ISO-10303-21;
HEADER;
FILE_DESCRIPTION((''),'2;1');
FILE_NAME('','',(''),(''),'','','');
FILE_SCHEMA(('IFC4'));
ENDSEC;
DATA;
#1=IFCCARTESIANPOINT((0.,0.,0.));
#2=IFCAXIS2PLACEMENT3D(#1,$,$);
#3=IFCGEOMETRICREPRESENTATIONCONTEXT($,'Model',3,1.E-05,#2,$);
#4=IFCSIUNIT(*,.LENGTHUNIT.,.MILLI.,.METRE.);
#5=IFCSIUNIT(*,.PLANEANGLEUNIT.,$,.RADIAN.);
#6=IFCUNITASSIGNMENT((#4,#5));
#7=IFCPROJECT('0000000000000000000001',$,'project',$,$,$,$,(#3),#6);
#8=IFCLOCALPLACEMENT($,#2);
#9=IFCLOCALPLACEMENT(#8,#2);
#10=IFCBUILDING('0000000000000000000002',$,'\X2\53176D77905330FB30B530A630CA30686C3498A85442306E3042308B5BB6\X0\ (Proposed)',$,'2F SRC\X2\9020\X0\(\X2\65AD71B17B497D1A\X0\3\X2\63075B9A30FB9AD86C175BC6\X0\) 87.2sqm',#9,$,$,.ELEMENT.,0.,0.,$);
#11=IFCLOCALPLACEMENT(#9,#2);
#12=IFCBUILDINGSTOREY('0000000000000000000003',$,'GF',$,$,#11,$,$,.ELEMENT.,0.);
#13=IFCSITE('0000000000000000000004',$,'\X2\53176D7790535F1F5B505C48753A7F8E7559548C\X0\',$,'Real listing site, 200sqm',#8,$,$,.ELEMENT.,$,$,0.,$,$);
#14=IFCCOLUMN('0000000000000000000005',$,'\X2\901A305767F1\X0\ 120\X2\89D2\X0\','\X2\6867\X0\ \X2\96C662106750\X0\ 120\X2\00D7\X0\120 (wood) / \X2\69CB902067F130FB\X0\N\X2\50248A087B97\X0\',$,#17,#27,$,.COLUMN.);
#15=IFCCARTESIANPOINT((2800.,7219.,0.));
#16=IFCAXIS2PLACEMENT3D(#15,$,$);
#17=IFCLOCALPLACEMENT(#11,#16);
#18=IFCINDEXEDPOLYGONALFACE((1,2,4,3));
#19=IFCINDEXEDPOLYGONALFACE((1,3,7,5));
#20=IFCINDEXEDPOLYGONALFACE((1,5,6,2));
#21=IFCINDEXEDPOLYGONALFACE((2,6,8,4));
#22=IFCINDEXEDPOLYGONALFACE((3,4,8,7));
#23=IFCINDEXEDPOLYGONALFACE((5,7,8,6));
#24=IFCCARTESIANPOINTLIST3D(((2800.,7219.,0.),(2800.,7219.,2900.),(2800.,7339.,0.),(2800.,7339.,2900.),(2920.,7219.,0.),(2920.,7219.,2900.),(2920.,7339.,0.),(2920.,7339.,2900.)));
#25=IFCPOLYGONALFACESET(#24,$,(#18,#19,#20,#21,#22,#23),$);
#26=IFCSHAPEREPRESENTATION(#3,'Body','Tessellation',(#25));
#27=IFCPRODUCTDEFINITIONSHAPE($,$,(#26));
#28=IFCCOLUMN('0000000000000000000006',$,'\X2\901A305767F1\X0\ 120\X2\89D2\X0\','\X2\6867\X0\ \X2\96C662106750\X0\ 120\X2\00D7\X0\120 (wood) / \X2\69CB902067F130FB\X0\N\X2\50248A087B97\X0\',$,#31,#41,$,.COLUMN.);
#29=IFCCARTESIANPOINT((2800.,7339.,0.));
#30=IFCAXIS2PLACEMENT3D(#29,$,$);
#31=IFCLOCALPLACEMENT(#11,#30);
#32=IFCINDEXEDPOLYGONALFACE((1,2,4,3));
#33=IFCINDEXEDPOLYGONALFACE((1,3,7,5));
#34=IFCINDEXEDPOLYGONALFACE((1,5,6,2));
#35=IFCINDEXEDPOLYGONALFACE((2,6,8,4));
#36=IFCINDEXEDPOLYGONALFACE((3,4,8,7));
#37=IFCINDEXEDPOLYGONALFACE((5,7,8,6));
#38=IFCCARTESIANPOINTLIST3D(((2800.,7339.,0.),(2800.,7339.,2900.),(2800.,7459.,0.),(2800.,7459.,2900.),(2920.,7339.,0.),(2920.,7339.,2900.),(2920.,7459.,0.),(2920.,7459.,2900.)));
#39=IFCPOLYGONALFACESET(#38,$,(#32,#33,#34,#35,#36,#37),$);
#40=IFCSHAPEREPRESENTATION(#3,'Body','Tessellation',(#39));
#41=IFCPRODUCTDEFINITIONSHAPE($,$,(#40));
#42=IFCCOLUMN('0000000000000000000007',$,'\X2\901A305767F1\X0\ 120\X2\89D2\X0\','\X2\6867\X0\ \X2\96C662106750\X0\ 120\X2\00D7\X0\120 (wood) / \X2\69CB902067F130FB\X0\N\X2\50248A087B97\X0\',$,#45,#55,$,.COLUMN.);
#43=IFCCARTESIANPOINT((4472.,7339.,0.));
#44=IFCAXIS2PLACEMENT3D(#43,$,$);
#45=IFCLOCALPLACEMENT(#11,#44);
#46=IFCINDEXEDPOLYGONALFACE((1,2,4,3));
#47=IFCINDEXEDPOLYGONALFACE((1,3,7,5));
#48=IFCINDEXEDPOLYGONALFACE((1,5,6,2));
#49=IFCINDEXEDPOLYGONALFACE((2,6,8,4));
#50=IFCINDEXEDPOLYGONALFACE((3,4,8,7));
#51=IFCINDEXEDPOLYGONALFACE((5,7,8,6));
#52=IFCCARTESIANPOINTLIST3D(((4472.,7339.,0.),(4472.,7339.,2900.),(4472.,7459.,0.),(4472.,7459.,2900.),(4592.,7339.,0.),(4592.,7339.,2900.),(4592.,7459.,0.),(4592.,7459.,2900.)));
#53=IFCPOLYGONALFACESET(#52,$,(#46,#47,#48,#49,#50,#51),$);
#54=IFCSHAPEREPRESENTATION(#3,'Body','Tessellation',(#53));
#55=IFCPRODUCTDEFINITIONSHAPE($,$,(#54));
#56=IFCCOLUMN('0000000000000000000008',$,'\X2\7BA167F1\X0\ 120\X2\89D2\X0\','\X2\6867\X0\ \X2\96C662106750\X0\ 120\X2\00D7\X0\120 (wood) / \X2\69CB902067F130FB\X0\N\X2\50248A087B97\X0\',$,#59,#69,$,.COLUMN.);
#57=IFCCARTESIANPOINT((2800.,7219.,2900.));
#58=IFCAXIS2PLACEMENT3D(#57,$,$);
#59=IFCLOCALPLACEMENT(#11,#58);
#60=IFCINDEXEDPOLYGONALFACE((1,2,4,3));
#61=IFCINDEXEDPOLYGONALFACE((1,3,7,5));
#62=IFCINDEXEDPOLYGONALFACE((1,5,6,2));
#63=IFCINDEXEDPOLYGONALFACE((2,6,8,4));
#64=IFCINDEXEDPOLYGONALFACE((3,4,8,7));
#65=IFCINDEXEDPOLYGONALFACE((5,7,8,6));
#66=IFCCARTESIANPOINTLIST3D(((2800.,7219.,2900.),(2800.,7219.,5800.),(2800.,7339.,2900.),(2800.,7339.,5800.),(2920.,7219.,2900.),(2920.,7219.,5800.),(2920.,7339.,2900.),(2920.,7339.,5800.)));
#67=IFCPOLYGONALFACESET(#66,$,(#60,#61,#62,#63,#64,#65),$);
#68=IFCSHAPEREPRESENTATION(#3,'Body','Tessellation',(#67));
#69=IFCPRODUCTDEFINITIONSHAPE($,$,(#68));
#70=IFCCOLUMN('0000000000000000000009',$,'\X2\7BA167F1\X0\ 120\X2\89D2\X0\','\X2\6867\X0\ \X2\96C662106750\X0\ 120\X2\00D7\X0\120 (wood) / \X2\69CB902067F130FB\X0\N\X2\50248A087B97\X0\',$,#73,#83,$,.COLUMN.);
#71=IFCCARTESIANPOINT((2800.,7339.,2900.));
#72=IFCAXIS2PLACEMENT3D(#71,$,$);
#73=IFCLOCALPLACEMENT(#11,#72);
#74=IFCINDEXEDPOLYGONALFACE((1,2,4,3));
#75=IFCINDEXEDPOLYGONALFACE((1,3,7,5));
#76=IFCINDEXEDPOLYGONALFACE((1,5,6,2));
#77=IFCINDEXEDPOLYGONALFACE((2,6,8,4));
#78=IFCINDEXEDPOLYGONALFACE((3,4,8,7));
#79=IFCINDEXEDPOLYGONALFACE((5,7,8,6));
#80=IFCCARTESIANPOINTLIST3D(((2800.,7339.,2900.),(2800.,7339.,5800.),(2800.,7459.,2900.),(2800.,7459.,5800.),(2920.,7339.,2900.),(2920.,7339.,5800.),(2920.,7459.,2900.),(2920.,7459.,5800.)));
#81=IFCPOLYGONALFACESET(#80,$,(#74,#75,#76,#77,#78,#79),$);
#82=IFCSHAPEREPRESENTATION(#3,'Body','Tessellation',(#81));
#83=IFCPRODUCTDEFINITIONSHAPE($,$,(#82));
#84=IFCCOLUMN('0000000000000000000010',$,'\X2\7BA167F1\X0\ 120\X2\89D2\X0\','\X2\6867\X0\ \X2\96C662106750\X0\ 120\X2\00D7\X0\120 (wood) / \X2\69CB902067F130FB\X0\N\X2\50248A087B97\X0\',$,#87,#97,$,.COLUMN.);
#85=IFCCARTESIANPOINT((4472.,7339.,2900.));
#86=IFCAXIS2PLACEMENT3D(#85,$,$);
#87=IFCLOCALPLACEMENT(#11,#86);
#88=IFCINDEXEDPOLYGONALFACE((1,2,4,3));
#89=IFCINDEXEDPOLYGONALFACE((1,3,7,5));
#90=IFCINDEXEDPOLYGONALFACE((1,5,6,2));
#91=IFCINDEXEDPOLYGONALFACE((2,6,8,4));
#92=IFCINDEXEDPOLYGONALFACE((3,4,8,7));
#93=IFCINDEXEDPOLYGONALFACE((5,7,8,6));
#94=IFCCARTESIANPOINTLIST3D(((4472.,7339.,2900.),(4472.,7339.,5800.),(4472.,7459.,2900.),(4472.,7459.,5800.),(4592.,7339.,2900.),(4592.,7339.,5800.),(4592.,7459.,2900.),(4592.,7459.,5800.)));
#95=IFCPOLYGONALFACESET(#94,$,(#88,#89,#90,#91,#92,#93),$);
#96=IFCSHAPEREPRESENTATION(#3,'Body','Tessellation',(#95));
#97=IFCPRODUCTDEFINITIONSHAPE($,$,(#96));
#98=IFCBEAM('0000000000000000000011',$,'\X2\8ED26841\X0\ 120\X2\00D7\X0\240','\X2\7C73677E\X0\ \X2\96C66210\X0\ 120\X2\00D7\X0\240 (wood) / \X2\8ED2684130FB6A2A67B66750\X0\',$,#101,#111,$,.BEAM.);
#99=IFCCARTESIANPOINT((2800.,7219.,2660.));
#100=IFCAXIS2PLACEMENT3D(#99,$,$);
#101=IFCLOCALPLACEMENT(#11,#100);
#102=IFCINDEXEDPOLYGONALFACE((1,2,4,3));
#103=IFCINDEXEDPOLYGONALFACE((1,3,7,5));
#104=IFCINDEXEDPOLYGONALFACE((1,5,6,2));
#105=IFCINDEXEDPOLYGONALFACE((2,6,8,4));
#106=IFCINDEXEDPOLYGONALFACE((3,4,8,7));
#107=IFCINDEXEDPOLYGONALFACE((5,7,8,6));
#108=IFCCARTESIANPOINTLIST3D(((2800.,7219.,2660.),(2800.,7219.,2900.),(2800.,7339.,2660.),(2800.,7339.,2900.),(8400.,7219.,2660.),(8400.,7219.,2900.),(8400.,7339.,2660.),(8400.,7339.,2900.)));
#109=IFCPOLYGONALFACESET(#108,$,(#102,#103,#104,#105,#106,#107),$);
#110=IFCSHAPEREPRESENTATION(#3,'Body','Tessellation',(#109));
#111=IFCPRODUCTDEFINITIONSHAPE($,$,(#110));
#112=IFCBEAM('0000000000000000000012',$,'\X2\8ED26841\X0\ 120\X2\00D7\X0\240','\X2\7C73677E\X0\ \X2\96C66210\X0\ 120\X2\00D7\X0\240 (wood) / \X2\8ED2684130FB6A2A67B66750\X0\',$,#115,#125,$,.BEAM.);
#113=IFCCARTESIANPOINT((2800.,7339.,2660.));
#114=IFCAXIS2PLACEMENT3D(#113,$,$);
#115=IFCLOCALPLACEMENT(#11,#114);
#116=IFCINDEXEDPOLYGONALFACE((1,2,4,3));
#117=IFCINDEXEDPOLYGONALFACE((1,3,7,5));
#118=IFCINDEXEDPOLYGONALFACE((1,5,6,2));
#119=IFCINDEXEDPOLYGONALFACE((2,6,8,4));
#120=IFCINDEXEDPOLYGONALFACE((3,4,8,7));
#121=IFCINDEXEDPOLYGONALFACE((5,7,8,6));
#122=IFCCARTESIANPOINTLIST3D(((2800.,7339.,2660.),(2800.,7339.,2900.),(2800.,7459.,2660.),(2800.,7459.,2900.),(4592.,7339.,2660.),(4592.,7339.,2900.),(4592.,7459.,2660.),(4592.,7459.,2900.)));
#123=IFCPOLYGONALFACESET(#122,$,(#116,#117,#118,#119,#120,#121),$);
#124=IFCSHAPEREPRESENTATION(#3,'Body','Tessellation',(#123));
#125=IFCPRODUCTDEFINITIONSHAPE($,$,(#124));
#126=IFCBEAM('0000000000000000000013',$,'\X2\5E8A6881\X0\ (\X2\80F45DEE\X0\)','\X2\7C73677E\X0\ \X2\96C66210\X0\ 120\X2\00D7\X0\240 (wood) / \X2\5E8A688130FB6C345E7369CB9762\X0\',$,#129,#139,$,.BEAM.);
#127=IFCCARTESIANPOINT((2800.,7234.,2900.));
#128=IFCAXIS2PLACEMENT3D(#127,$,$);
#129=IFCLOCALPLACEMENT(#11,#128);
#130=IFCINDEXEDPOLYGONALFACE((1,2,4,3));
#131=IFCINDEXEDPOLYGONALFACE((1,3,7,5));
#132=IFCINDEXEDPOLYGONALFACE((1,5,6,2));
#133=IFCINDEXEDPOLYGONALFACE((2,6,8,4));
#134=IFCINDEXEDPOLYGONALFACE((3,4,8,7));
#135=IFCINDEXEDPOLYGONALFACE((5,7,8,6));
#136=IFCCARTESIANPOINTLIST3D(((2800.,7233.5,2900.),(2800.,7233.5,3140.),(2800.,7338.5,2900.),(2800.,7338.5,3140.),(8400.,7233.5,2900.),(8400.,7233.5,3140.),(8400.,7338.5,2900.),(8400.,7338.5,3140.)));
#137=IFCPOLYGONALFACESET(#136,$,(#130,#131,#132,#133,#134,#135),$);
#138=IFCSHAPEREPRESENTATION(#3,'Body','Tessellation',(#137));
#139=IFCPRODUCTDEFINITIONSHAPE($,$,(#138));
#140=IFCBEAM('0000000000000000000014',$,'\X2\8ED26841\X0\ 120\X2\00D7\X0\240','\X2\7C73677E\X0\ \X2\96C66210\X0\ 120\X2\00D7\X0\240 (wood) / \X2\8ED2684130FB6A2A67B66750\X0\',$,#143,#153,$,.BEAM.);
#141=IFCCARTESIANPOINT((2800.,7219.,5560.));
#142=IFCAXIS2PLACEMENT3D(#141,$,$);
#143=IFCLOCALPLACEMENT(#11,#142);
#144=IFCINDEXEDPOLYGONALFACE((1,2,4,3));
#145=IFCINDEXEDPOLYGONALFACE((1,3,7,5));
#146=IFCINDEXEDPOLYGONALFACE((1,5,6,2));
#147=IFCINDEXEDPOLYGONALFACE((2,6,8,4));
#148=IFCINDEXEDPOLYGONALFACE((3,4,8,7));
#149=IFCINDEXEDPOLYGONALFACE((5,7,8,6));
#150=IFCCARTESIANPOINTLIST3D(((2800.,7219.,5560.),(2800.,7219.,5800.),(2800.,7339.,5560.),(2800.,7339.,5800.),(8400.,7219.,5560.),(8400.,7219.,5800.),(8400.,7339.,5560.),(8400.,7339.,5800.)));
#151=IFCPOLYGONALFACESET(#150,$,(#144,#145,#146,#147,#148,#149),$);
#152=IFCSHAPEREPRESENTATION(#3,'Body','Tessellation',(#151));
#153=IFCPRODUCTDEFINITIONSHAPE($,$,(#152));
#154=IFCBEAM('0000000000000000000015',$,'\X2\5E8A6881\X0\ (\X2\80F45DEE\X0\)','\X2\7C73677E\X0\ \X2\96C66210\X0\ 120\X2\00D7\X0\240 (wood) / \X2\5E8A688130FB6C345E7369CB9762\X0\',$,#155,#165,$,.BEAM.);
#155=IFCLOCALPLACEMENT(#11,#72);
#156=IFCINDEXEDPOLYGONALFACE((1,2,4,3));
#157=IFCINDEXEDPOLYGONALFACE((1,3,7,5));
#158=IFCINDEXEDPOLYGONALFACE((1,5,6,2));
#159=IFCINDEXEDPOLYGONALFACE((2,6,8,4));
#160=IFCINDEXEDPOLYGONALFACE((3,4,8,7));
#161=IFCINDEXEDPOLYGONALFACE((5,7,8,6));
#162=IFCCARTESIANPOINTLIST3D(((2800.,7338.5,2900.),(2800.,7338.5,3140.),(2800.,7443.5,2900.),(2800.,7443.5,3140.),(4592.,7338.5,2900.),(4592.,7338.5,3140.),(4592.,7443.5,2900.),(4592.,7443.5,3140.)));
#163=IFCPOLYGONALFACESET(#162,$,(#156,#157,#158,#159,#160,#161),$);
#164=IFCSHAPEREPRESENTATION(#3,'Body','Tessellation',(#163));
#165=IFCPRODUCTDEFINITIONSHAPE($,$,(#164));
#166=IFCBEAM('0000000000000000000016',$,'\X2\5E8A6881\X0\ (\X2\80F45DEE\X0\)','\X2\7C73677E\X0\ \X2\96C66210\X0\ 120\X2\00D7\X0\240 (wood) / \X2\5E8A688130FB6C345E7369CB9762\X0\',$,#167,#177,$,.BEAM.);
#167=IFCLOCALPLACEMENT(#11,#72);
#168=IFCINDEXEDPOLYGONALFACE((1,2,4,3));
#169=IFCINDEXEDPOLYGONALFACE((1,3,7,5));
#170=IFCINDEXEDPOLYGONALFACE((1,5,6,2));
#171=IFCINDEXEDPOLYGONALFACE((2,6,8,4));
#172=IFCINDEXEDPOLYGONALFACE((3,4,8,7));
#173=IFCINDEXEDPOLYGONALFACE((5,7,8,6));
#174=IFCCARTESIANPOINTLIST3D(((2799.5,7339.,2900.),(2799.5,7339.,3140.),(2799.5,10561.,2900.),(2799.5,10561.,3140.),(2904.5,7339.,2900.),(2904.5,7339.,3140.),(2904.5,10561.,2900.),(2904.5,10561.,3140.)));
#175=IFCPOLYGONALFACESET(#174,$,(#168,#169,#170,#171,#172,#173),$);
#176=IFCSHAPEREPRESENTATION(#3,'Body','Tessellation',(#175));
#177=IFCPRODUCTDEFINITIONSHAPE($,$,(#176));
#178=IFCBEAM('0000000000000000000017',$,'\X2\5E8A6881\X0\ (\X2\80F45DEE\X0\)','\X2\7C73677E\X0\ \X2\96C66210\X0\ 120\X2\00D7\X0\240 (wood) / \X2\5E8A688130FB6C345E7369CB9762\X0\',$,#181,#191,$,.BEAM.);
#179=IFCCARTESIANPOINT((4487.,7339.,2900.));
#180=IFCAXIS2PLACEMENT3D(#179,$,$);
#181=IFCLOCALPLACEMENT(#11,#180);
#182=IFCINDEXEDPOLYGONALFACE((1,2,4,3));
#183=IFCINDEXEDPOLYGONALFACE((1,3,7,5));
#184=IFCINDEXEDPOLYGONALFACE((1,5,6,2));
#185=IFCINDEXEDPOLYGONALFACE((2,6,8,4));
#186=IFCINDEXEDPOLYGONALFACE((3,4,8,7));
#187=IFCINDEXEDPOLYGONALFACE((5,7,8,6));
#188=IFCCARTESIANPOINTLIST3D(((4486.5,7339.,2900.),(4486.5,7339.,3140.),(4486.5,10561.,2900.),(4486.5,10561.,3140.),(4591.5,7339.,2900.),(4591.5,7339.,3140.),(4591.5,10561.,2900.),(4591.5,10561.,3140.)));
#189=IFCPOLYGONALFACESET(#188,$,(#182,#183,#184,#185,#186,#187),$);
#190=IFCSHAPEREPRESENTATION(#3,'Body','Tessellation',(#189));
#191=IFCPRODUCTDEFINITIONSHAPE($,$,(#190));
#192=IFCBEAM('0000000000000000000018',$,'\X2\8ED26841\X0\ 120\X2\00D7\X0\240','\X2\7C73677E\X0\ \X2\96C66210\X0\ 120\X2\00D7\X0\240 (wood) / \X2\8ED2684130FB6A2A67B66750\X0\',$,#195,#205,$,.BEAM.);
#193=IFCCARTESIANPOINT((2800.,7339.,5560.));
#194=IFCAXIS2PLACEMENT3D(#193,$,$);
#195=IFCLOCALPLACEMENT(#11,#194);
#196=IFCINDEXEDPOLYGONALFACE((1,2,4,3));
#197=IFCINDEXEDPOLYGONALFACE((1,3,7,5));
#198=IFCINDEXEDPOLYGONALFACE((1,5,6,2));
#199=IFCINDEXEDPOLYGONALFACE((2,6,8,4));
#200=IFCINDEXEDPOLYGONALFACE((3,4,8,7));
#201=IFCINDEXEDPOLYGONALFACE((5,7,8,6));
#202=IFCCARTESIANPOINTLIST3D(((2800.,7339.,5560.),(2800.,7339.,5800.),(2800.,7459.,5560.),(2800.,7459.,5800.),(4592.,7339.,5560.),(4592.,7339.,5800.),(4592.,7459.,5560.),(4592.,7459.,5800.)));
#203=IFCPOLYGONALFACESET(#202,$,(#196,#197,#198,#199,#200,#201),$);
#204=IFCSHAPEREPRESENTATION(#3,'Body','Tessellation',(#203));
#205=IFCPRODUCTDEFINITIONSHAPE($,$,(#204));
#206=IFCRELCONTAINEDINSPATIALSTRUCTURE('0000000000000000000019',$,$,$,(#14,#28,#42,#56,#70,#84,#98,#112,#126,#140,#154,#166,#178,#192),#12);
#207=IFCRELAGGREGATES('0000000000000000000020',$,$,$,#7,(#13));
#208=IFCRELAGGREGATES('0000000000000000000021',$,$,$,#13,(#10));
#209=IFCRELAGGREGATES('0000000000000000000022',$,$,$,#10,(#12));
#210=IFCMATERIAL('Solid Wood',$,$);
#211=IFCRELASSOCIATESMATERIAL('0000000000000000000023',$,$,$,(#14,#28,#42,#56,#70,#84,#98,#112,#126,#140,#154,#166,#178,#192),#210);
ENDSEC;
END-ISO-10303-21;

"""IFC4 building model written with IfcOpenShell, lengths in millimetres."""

from ifc_helpers import new_model, si_unit, frame, frame_2d, origin, place, context, project, spatial, rectangle, extrude, material, element, save


model = new_model("IFC4")

# Units and contexts
model_context = context("Model", 3, precision=1e-05, world=origin())
ifc_project = project(units=[si_unit("LENGTHUNIT", "METRE", prefix="MILLI"), si_unit("PLANEANGLEUNIT", "RADIAN")], contexts=[model_context])

# Site, building, storey
site_placement = place(None, origin())
site = spatial("IfcSite", under=ifc_project, at=site_placement, Name="北海道弟子屈町美留和", ObjectType="Real listing site, 200sqm", CompositionType="ELEMENT", RefElevation=0.0)
building_placement = place(site_placement, origin())
building = spatial("IfcBuilding", under=site, at=building_placement, Name="北海道・サウナと水風呂のある家 (Proposed)", ObjectType="2F SRC造(断熱等級3指定・高気密) 87.2sqm", CompositionType="ELEMENT", ElevationOfRefHeight=0.0, ElevationOfTerrain=0.0)
storey_placement = place(building_placement, origin())
storey = spatial("IfcBuildingStorey", under=building, at=storey_placement, Name="GF", CompositionType="ELEMENT", Elevation=0.0)

# Columns
ifc_material_1 = material(Name="Solid Wood")
column_1_placement = place(storey_placement, frame((2800.0, 7219.0, 0.0)))
element("IfcColumn", 1, at=column_1_placement, inside=storey, material=ifc_material_1, Name="通し柱 120角", Description="桧 集成材 120×120 (wood) / 構造柱・N値計算", PredefinedType="COLUMN", context=model_context, shape_type="SweptSolid", body=[
    extrude(rectangle(XDim=120.0, YDim=120.0, at=frame_2d((60.0, 60.0))), frame((2800.0, 7219.0, 0.0)), (0.0, 0.0, 1.0), 2900.0),
])
column_2_placement = place(storey_placement, frame((2800.0, 7339.0, 0.0)))
element("IfcColumn", 2, at=column_2_placement, inside=storey, material=ifc_material_1, Name="通し柱 120角", Description="桧 集成材 120×120 (wood) / 構造柱・N値計算", PredefinedType="COLUMN", context=model_context, shape_type="SweptSolid", body=[
    extrude(rectangle(XDim=120.0, YDim=120.0, at=frame_2d((60.0, 60.0))), frame((2800.0, 7339.0, 0.0)), (0.0, 0.0, 1.0), 2900.0),
])
column_3_placement = place(storey_placement, frame((4472.0, 7339.0, 0.0)))
element("IfcColumn", 3, at=column_3_placement, inside=storey, material=ifc_material_1, Name="通し柱 120角", Description="桧 集成材 120×120 (wood) / 構造柱・N値計算", PredefinedType="COLUMN", context=model_context, shape_type="SweptSolid", body=[
    extrude(rectangle(XDim=120.0, YDim=120.0, at=frame_2d((60.0, 60.0))), frame((4472.0, 7339.0, 0.0)), (0.0, 0.0, 1.0), 2900.0),
])
column_4_placement = place(storey_placement, frame((2800.0, 7219.0, 2900.0)))
element("IfcColumn", 4, at=column_4_placement, inside=storey, material=ifc_material_1, Name="管柱 120角", Description="桧 集成材 120×120 (wood) / 構造柱・N値計算", PredefinedType="COLUMN", context=model_context, shape_type="SweptSolid", body=[
    extrude(rectangle(XDim=120.0, YDim=120.0, at=frame_2d((60.0, 60.0))), frame((2800.0, 7219.0, 2900.0)), (0.0, 0.0, 1.0), 2900.0),
])
column_5_placement = place(storey_placement, frame((2800.0, 7339.0, 2900.0)))
element("IfcColumn", 5, at=column_5_placement, inside=storey, material=ifc_material_1, Name="管柱 120角", Description="桧 集成材 120×120 (wood) / 構造柱・N値計算", PredefinedType="COLUMN", context=model_context, shape_type="SweptSolid", body=[
    extrude(rectangle(XDim=120.0, YDim=120.0, at=frame_2d((60.0, 60.0))), frame((2800.0, 7339.0, 2900.0)), (0.0, 0.0, 1.0), 2900.0),
])
column_6_placement = place(storey_placement, frame((4472.0, 7339.0, 2900.0)))
element("IfcColumn", 6, at=column_6_placement, inside=storey, material=ifc_material_1, Name="管柱 120角", Description="桧 集成材 120×120 (wood) / 構造柱・N値計算", PredefinedType="COLUMN", context=model_context, shape_type="SweptSolid", body=[
    extrude(rectangle(XDim=120.0, YDim=120.0, at=frame_2d((60.0, 60.0))), frame((4472.0, 7339.0, 2900.0)), (0.0, 0.0, 1.0), 2900.0),
])

# Beams
beam_1_placement = place(storey_placement, frame((2800.0, 7219.0, 2660.0)))
element("IfcBeam", 7, at=beam_1_placement, inside=storey, material=ifc_material_1, Name="軒桁 120×240", Description="米松 集成 120×240 (wood) / 軒桁・横架材", PredefinedType="BEAM", context=model_context, shape_type="SweptSolid", body=[
    extrude(rectangle(XDim=5600.0, YDim=120.0, at=frame_2d((2800.0, 60.0))), frame((2800.0, 7219.0, 2660.0)), (0.0, 0.0, 1.0), 240.0),
])
beam_2_placement = place(storey_placement, frame((2800.0, 7339.0, 2660.0)))
element("IfcBeam", 8, at=beam_2_placement, inside=storey, material=ifc_material_1, Name="軒桁 120×240", Description="米松 集成 120×240 (wood) / 軒桁・横架材", PredefinedType="BEAM", context=model_context, shape_type="SweptSolid", body=[
    extrude(rectangle(XDim=1792.0, YDim=120.0, at=frame_2d((896.0, 60.0))), frame((2800.0, 7339.0, 2660.0)), (0.0, 0.0, 1.0), 240.0),
])
beam_3_placement = place(storey_placement, frame((2800.0, 7234.0, 2900.0)))
element("IfcBeam", 9, at=beam_3_placement, inside=storey, material=ifc_material_1, Name="床梁 (胴差)", Description="米松 集成 120×240 (wood) / 床梁・水平構面", PredefinedType="BEAM", context=model_context, shape_type="SweptSolid", body=[
    extrude(rectangle(XDim=5600.0, YDim=105.0, at=frame_2d((2800.0, 52.0))), frame((2800.0, 7234.0, 2900.0)), (0.0, 0.0, 1.0), 240.0),
])
beam_4_placement = place(storey_placement, frame((2800.0, 7219.0, 5560.0)))
element("IfcBeam", 10, at=beam_4_placement, inside=storey, material=ifc_material_1, Name="軒桁 120×240", Description="米松 集成 120×240 (wood) / 軒桁・横架材", PredefinedType="BEAM", context=model_context, shape_type="SweptSolid", body=[
    extrude(rectangle(XDim=5600.0, YDim=120.0, at=frame_2d((2800.0, 60.0))), frame((2800.0, 7219.0, 5560.0)), (0.0, 0.0, 1.0), 240.0),
])
beam_5_placement = place(storey_placement, frame((2800.0, 7339.0, 2900.0)))
element("IfcBeam", 11, at=beam_5_placement, inside=storey, material=ifc_material_1, Name="床梁 (胴差)", Description="米松 集成 120×240 (wood) / 床梁・水平構面", PredefinedType="BEAM", context=model_context, shape_type="SweptSolid", body=[
    extrude(rectangle(XDim=1792.0, YDim=105.0, at=frame_2d((896.0, 52.0))), frame((2800.0, 7339.0, 2900.0)), (0.0, 0.0, 1.0), 240.0),
])
beam_6_placement = place(storey_placement, frame((2800.0, 7339.0, 2900.0)))
element("IfcBeam", 12, at=beam_6_placement, inside=storey, material=ifc_material_1, Name="床梁 (胴差)", Description="米松 集成 120×240 (wood) / 床梁・水平構面", PredefinedType="BEAM", context=model_context, shape_type="SweptSolid", body=[
    extrude(rectangle(XDim=105.0, YDim=3222.0, at=frame_2d((52.0, 1611.0))), frame((2800.0, 7339.0, 2900.0)), (0.0, 0.0, 1.0), 240.0),
])
beam_7_placement = place(storey_placement, frame((4487.0, 7339.0, 2900.0)))
element("IfcBeam", 13, at=beam_7_placement, inside=storey, material=ifc_material_1, Name="床梁 (胴差)", Description="米松 集成 120×240 (wood) / 床梁・水平構面", PredefinedType="BEAM", context=model_context, shape_type="SweptSolid", body=[
    extrude(rectangle(XDim=105.0, YDim=3222.0, at=frame_2d((52.0, 1611.0))), frame((4487.0, 7339.0, 2900.0)), (0.0, 0.0, 1.0), 240.0),
])
beam_8_placement = place(storey_placement, frame((2800.0, 7339.0, 5560.0)))
element("IfcBeam", 14, at=beam_8_placement, inside=storey, material=ifc_material_1, Name="軒桁 120×240", Description="米松 集成 120×240 (wood) / 軒桁・横架材", PredefinedType="BEAM", context=model_context, shape_type="SweptSolid", body=[
    extrude(rectangle(XDim=1792.0, YDim=120.0, at=frame_2d((896.0, 60.0))), frame((2800.0, 7339.0, 5560.0)), (0.0, 0.0, 1.0), 240.0),
])

save(model, "model.ifc")
